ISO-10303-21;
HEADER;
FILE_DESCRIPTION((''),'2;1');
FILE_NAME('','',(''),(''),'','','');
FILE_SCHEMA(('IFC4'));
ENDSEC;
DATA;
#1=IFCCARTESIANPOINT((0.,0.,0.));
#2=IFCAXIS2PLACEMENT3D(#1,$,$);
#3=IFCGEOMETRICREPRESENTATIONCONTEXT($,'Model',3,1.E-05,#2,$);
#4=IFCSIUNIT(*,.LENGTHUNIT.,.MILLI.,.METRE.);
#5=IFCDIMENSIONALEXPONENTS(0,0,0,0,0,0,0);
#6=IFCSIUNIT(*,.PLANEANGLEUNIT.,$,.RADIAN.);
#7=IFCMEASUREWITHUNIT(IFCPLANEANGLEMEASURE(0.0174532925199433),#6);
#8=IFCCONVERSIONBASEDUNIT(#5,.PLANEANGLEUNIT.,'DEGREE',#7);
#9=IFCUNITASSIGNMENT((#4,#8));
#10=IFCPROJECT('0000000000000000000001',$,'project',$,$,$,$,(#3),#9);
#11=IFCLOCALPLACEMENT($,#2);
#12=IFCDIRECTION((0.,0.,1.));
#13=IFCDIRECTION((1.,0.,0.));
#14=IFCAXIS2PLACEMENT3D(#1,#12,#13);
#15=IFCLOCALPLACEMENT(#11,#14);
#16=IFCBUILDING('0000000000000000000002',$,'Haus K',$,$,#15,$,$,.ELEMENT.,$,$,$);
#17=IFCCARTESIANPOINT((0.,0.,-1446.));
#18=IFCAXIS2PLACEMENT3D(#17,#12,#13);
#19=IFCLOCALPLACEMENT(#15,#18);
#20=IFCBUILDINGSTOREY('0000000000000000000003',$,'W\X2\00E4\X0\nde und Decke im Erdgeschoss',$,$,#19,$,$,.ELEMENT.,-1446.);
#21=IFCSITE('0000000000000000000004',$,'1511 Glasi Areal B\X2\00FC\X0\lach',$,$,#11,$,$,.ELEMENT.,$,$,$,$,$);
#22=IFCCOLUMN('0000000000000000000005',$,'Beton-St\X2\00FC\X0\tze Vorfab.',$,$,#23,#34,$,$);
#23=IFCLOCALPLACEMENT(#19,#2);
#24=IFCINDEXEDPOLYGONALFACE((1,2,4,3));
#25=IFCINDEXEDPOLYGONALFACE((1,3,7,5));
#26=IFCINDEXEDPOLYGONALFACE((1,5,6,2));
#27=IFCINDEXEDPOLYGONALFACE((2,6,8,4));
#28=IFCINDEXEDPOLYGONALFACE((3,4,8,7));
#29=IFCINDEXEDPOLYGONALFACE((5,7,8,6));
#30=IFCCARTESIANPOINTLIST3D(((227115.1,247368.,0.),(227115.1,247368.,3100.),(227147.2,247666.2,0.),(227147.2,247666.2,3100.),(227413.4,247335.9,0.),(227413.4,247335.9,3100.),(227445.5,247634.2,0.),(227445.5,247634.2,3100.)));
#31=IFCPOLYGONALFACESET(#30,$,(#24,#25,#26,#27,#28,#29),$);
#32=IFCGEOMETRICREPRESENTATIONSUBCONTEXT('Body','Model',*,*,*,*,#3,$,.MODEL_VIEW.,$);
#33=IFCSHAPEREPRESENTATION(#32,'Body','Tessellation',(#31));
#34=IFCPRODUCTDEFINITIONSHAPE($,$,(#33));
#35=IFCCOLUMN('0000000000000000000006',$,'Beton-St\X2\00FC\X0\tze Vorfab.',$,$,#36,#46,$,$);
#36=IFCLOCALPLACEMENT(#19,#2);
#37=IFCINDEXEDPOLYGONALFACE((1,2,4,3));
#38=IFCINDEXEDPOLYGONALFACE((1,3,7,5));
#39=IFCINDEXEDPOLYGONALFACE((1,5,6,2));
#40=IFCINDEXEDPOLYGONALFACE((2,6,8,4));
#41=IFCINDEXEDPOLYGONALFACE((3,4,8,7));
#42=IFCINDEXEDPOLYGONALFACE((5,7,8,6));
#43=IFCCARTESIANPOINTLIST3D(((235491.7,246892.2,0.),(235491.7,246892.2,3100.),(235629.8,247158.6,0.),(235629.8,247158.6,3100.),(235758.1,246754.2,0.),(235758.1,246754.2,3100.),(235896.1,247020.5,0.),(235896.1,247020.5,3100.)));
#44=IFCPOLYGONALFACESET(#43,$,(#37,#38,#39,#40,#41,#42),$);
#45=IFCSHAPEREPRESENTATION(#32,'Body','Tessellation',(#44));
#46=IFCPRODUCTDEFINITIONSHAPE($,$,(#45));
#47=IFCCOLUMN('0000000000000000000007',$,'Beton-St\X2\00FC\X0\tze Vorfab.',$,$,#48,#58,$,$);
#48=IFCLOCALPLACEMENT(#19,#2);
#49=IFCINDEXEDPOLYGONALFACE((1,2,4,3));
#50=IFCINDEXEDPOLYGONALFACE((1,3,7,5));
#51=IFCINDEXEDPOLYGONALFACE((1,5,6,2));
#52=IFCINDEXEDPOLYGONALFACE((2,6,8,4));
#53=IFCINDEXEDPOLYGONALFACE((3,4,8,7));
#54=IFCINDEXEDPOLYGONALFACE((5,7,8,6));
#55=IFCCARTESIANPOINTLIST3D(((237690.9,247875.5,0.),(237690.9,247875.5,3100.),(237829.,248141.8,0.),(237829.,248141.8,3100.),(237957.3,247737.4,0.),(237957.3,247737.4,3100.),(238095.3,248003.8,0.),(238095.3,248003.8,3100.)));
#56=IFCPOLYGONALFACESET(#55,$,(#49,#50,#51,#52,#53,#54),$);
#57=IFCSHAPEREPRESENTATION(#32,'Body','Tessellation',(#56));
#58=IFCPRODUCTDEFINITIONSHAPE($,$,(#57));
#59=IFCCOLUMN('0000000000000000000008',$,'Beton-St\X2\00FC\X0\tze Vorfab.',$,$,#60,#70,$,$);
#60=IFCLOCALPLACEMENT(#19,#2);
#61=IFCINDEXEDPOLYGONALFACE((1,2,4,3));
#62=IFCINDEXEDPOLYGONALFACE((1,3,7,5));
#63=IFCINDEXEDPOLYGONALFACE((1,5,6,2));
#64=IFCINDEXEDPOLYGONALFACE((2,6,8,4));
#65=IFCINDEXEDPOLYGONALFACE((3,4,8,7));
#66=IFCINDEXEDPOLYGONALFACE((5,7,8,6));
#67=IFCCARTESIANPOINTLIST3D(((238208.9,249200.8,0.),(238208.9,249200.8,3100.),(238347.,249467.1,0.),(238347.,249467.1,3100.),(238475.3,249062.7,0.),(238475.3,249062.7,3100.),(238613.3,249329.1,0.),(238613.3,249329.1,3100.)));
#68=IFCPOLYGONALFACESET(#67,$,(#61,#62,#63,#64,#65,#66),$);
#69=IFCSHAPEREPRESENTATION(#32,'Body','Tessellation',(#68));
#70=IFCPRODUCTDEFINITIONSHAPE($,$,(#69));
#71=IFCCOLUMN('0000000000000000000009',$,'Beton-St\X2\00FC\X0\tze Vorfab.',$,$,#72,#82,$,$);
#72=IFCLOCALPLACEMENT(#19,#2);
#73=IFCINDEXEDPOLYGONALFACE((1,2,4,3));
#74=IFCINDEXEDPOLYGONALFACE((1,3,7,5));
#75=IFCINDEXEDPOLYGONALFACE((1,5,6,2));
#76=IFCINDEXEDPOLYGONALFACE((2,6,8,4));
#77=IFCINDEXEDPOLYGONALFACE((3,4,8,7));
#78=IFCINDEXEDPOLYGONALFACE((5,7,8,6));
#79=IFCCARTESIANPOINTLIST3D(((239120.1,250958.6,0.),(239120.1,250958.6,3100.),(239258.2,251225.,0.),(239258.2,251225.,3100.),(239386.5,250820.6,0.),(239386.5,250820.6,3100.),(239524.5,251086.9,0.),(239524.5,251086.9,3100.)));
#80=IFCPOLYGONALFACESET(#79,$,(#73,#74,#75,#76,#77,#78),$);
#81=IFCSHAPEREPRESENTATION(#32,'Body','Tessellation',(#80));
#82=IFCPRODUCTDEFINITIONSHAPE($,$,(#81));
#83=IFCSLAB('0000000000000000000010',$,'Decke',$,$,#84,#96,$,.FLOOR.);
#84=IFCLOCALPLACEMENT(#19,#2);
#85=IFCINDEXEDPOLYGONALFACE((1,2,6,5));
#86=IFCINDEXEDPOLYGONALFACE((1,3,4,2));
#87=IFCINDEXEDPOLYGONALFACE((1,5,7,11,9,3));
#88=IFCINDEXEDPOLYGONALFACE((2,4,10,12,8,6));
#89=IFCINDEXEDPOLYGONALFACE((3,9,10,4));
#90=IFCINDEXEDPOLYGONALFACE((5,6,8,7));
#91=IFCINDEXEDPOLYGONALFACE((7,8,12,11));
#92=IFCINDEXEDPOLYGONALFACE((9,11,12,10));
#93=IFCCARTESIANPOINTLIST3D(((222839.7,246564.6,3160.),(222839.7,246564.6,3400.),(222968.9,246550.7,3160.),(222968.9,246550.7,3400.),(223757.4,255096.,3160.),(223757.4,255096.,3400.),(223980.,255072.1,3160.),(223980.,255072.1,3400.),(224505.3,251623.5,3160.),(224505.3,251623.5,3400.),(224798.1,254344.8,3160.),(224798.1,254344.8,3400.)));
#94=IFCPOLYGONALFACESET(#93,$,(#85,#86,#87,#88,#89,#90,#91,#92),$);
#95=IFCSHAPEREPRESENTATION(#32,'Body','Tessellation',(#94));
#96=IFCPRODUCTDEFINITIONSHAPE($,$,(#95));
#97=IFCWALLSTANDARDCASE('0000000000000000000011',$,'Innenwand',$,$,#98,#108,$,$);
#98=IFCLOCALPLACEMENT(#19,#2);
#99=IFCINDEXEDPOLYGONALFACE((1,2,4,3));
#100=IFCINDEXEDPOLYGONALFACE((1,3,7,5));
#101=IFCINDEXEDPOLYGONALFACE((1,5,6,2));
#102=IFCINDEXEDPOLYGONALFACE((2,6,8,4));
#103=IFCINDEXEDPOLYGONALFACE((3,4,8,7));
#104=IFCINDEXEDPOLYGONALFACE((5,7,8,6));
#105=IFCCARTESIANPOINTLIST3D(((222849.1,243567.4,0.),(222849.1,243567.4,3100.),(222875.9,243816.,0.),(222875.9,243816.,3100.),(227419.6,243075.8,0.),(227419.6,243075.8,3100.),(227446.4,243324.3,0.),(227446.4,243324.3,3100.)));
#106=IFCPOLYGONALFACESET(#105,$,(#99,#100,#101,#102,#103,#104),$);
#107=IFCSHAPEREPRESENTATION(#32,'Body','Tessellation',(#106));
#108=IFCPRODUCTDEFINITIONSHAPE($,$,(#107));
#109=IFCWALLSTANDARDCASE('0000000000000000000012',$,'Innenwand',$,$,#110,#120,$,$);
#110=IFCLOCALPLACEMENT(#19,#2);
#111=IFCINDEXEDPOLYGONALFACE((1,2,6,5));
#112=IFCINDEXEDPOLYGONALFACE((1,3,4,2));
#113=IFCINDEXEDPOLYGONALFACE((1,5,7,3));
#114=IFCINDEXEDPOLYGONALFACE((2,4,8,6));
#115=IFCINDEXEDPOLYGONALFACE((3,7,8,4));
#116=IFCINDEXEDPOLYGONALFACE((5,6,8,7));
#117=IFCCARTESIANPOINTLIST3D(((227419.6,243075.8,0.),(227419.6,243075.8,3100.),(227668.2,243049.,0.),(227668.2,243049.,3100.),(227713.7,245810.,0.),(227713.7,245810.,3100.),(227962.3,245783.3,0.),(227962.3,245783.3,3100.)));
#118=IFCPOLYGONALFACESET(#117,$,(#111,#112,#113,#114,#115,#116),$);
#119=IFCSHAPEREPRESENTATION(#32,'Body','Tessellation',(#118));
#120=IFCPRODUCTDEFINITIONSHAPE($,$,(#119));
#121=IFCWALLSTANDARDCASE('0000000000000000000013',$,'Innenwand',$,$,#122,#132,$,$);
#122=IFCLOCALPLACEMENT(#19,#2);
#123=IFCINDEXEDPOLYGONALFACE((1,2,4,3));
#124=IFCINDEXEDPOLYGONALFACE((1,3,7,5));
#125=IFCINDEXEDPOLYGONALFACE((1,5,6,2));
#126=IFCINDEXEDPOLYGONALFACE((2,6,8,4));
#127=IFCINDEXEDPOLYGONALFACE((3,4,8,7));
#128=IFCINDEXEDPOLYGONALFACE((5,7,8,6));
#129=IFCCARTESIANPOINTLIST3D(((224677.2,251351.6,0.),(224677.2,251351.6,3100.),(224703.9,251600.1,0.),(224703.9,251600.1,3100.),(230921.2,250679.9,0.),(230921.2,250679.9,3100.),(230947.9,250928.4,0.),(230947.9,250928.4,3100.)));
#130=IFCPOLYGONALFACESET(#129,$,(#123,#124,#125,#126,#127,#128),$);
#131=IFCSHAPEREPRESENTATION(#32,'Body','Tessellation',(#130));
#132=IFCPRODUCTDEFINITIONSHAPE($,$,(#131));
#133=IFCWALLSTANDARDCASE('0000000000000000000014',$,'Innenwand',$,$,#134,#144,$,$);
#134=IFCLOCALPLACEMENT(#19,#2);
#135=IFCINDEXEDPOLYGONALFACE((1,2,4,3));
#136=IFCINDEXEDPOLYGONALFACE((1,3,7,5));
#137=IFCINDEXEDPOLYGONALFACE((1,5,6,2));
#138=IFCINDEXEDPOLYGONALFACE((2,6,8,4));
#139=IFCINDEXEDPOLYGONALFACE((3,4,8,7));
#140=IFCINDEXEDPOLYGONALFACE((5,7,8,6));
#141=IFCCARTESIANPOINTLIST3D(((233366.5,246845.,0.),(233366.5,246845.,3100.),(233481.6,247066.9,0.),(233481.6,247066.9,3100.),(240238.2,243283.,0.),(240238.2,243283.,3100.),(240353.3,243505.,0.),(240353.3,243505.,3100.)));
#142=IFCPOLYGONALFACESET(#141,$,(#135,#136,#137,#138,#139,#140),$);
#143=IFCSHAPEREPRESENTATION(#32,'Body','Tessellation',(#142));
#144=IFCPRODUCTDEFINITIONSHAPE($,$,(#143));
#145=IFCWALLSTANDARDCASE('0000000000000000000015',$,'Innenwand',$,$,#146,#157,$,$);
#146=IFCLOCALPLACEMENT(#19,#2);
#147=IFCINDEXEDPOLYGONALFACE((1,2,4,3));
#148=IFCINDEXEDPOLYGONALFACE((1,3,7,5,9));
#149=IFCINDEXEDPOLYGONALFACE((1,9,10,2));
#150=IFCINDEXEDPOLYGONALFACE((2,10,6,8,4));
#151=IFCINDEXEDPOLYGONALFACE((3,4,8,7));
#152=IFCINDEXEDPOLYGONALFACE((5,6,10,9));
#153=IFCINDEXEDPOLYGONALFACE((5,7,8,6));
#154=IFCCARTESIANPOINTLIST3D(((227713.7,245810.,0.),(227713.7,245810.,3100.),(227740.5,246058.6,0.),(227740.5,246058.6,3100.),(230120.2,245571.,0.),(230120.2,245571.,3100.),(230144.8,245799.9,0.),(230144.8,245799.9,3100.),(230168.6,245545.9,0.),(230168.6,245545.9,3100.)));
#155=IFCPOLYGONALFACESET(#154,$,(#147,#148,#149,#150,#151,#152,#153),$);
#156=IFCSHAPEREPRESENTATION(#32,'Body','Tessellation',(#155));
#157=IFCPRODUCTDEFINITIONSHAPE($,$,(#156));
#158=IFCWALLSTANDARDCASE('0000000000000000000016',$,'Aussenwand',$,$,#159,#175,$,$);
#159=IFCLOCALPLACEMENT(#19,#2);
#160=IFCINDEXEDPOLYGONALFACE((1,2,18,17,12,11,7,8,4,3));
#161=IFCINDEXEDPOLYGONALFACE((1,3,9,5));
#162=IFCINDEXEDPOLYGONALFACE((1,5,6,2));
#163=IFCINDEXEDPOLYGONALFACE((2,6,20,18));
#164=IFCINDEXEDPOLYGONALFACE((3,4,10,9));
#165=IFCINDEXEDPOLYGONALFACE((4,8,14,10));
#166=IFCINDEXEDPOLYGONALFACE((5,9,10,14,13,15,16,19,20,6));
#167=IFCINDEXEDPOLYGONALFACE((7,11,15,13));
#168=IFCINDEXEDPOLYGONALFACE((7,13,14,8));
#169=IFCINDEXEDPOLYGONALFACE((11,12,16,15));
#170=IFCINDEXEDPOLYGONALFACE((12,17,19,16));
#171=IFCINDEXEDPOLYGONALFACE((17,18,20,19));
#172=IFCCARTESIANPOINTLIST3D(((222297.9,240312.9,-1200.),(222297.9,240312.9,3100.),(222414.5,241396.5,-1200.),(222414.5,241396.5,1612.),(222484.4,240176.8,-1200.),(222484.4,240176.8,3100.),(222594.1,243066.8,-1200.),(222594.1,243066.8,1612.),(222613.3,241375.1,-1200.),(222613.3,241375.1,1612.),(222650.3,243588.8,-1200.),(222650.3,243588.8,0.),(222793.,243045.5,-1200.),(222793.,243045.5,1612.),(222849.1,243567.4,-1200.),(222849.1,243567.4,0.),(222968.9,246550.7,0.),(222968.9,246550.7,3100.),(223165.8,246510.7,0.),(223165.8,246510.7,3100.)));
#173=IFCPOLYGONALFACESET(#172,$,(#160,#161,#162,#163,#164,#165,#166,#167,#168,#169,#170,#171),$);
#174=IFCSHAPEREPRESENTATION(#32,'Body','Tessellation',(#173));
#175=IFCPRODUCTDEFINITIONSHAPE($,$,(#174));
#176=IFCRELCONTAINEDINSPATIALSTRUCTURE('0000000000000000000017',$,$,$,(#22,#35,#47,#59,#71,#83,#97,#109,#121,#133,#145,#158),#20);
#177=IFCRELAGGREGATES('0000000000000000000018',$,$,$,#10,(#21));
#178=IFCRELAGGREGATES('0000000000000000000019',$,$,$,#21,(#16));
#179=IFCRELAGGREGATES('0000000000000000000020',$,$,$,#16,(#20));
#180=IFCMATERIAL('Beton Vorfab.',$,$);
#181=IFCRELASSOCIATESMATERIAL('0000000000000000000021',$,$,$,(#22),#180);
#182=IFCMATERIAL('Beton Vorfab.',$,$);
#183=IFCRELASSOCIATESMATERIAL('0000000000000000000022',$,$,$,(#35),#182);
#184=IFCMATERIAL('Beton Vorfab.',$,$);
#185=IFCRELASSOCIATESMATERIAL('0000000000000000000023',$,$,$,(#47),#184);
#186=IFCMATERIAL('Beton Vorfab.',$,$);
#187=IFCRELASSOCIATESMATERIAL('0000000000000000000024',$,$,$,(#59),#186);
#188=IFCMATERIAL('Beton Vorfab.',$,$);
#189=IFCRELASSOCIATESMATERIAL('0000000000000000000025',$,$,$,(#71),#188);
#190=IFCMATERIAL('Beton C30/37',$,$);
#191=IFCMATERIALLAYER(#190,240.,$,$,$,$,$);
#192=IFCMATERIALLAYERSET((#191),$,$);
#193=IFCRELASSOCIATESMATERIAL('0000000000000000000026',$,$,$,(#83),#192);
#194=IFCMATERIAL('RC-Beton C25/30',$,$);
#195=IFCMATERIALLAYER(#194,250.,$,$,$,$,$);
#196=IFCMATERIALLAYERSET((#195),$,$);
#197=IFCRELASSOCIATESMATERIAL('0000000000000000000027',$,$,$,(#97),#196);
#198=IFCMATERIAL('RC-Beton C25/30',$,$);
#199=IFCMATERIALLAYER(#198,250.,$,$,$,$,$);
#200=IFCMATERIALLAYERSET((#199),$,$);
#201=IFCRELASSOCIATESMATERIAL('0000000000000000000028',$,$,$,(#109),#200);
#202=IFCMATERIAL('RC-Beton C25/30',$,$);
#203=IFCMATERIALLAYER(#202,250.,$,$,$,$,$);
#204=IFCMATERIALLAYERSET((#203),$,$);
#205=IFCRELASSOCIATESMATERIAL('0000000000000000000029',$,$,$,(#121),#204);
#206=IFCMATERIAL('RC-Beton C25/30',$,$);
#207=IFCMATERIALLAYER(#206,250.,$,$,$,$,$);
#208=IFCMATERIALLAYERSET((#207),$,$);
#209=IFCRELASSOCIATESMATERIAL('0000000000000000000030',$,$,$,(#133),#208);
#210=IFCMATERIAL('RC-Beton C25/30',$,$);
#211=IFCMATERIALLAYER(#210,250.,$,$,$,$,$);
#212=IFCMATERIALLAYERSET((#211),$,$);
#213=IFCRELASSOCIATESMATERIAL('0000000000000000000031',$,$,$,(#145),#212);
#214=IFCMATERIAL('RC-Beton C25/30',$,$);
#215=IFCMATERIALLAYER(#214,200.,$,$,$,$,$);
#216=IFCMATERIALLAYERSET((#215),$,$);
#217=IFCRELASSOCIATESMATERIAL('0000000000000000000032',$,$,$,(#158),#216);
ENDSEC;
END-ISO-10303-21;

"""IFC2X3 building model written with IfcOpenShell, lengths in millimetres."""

from ifc_helpers import new_model, entity, si_unit, converted_unit, frame, frame_2d, origin, origin_with_axes, place, context, subcontext, project, spatial, polyline, rectangle, outline, extrude, clip, bounded_halfspace, material, layer, layer_set, layer_usage, element, save


model = new_model("IFC2X3")

# Units and contexts
model_context = context("Model", 3, precision=1e-05, world=origin())
body_context = subcontext(model_context, "Body", "Model", "MODEL_VIEW")
ifc_project = project(units=[si_unit("LENGTHUNIT", "METRE", prefix="MILLI"), converted_unit("PLANEANGLEUNIT", "DEGREE", entity("IfcPlaneAngleMeasure", 0.0174532925199433), si_unit("PLANEANGLEUNIT", "RADIAN"), dimensions=[0, 0, 0, 0, 0, 0, 0])], contexts=[model_context])

# Site, building, storey
site_placement = place(None, origin())
site = spatial("IfcSite", under=ifc_project, at=site_placement, Name="1511 Glasi Areal Bülach", CompositionType="ELEMENT")
building_placement = place(site_placement, origin_with_axes())
building = spatial("IfcBuilding", under=site, at=building_placement, Name="Haus K", CompositionType="ELEMENT")
storey_placement = place(building_placement, frame((0.0, 0.0, -1446.0), z_axis=(0.0, 0.0, 1.0), x_axis=(1.0, 0.0, 0.0)))
storey = spatial("IfcBuildingStorey", under=building, at=storey_placement, Name="Wände und Decke im Erdgeschoss", CompositionType="ELEMENT", Elevation=-1446.0)

# Columns
ifc_material_1 = material(Name="Beton Vorfab.")
column_1_placement = place(storey_placement, frame((227115.1, 247368.0, 0.0), z_axis=(0.0, 0.0, 1.0), x_axis=(1.0, 0.0, 0.0)))
element("IfcColumn", 1, at=column_1_placement, inside=storey, material=ifc_material_1, Name="Beton-Stütze Vorfab.", context=body_context, shape_type="SweptSolid", body=[
    extrude(rectangle(XDim=300.0, YDim=300.0, at=frame_2d((165.2, 133.1), x_axis=(0.994264, -0.106958))), origin_with_axes(), (0.0, 0.0, 1.0), 3100.0),
])
ifc_material_2 = material(Name="Beton Vorfab.")
column_2_placement = place(storey_placement, frame((235491.7, 246892.2, 0.0), z_axis=(0.0, 0.0, 1.0), x_axis=(1.0, 0.0, 0.0)))
element("IfcColumn", 2, at=column_2_placement, inside=storey, material=ifc_material_2, Name="Beton-Stütze Vorfab.", context=body_context, shape_type="SweptSolid", body=[
    extrude(rectangle(XDim=300.0, YDim=300.0, at=frame_2d((202.2, 64.1), x_axis=(0.887815, -0.4602))), origin_with_axes(), (0.0, 0.0, 1.0), 3100.0),
])
ifc_material_3 = material(Name="Beton Vorfab.")
column_3_placement = place(storey_placement, frame((237690.9, 247875.5, 0.0), z_axis=(0.0, 0.0, 1.0), x_axis=(1.0, 0.0, 0.0)))
element("IfcColumn", 3, at=column_3_placement, inside=storey, material=ifc_material_3, Name="Beton-Stütze Vorfab.", context=body_context, shape_type="SweptSolid", body=[
    extrude(rectangle(XDim=300.0, YDim=300.0, at=frame_2d((202.2, 64.1), x_axis=(0.887815, -0.4602))), origin_with_axes(), (0.0, 0.0, 1.0), 3100.0),
])
ifc_material_4 = material(Name="Beton Vorfab.")
column_4_placement = place(storey_placement, frame((238208.9, 249200.8, 0.0), z_axis=(0.0, 0.0, 1.0), x_axis=(1.0, 0.0, 0.0)))
element("IfcColumn", 4, at=column_4_placement, inside=storey, material=ifc_material_4, Name="Beton-Stütze Vorfab.", context=body_context, shape_type="SweptSolid", body=[
    extrude(rectangle(XDim=300.0, YDim=300.0, at=frame_2d((202.2, 64.1), x_axis=(0.887815, -0.4602))), origin_with_axes(), (0.0, 0.0, 1.0), 3100.0),
])
ifc_material_5 = material(Name="Beton Vorfab.")
column_5_placement = place(storey_placement, frame((239120.1, 250958.6, 0.0), z_axis=(0.0, 0.0, 1.0), x_axis=(1.0, 0.0, 0.0)))
element("IfcColumn", 5, at=column_5_placement, inside=storey, material=ifc_material_5, Name="Beton-Stütze Vorfab.", context=body_context, shape_type="SweptSolid", body=[
    extrude(rectangle(XDim=300.0, YDim=300.0, at=frame_2d((202.2, 64.1), x_axis=(0.887815, -0.4602))), origin_with_axes(), (0.0, 0.0, 1.0), 3100.0),
])

# Slab
ifc_material_6 = material(Name="Beton C30/37")
ifc_layer_1 = layer(ifc_material_6, 240.0)
ifc_layer_set_1 = layer_set([ifc_layer_1])
ifc_layer_usage_1 = layer_usage(ifc_layer_set_1, "AXIS3", "POSITIVE", 0.0)
slab_placement = place(storey_placement, frame((222839.7, 246550.7, 3160.0), z_axis=(0.0, 0.0, 1.0), x_axis=(1.0, 0.0, 0.0)))
element("IfcSlab", 6, at=slab_placement, inside=storey, material=ifc_layer_usage_1, Name="Decke", PredefinedType="FLOOR", context=body_context, shape_type="SweptSolid", body=[
    extrude(outline(polyline([(917.8, 8545.3), (0.0, 13.9), (129.3, 0.0), (1665.6, 5072.8), (1958.4, 7794.1), (1140.4, 8521.4), (917.8, 8545.3)])), origin_with_axes(), (0.0, 0.0, 1.0), 240.0),
])

# Walls
ifc_material_7 = material(Name="RC-Beton C25/30")
ifc_layer_2 = layer(ifc_material_7, 250.0)
ifc_layer_set_2 = layer_set([ifc_layer_2])
ifc_layer_usage_2 = layer_usage(ifc_layer_set_2, "AXIS2", "POSITIVE", 0.0)
wall_1_placement = place(storey_placement, frame((227446.4, 243324.3, 0.0), z_axis=(0.0, 0.0, 1.0), x_axis=(-0.994264, 0.106958, 0.0)))
element("IfcWallStandardCase", 7, at=wall_1_placement, inside=storey, material=ifc_layer_usage_2, Name="Innenwand", context=body_context, shape_type="SweptSolid", body=[
    extrude(rectangle(XDim=4596.8, YDim=250.0, at=frame_2d((2298.4, 125.0), x_axis=(1.0, 0.0))), origin_with_axes(), (0.0, 0.0, 1.0), 3100.0),
])
ifc_material_8 = material(Name="RC-Beton C25/30")
ifc_layer_3 = layer(ifc_material_8, 250.0)
ifc_layer_set_3 = layer_set([ifc_layer_3])
ifc_layer_usage_3 = layer_usage(ifc_layer_set_3, "AXIS2", "POSITIVE", 0.0)
wall_2_placement = place(storey_placement, frame((227713.7, 245810.0, 0.0), z_axis=(0.0, 0.0, 1.0), x_axis=(-0.106958, -0.994264, 0.0)))
element("IfcWallStandardCase", 8, at=wall_2_placement, inside=storey, material=ifc_layer_usage_3, Name="Innenwand", context=body_context, shape_type="SweptSolid", body=[
    extrude(rectangle(XDim=2750.0, YDim=250.0, at=frame_2d((1375.0, 125.0), x_axis=(1.0, 0.0))), origin_with_axes(), (0.0, 0.0, 1.0), 3100.0),
])
ifc_material_9 = material(Name="RC-Beton C25/30")
ifc_layer_4 = layer(ifc_material_9, 250.0)
ifc_layer_set_4 = layer_set([ifc_layer_4])
ifc_layer_usage_4 = layer_usage(ifc_layer_set_4, "AXIS2", "POSITIVE", 0.0)
wall_3_placement = place(storey_placement, frame((230947.9, 250928.4, 0.0), z_axis=(0.0, 0.0, 1.0), x_axis=(-0.994264, 0.106958, 0.0)))
element("IfcWallStandardCase", 9, at=wall_3_placement, inside=storey, material=ifc_layer_usage_4, Name="Innenwand", context=body_context, shape_type="SweptSolid", body=[
    extrude(rectangle(XDim=6280.0, YDim=250.0, at=frame_2d((3140.0, 125.0), x_axis=(1.0, 0.0))), origin_with_axes(), (0.0, 0.0, 1.0), 3100.0),
])
ifc_material_10 = material(Name="RC-Beton C25/30")
ifc_layer_5 = layer(ifc_material_10, 250.0)
ifc_layer_set_5 = layer_set([ifc_layer_5])
ifc_layer_usage_5 = layer_usage(ifc_layer_set_5, "AXIS2", "POSITIVE", 0.0)
wall_4_placement = place(storey_placement, frame((233366.5, 246845.0, 0.0), z_axis=(0.0, 0.0, 1.0), x_axis=(0.887815, -0.4602, 0.0)))
element("IfcWallStandardCase", 10, at=wall_4_placement, inside=storey, material=ifc_layer_usage_5, Name="Innenwand", context=body_context, shape_type="SweptSolid", body=[
    extrude(rectangle(XDim=7740.0, YDim=250.0, at=frame_2d((3870.0, 125.0), x_axis=(1.0, 0.0))), origin_with_axes(), (0.0, 0.0, 1.0), 3100.0),
])
ifc_material_11 = material(Name="RC-Beton C25/30")
ifc_layer_6 = layer(ifc_material_11, 250.0)
ifc_layer_set_6 = layer_set([ifc_layer_6])
ifc_layer_usage_6 = layer_usage(ifc_layer_set_6, "AXIS2", "POSITIVE", 0.0)
wall_5_placement = place(storey_placement, frame((230144.8, 245799.9, 0.0), z_axis=(0.0, 0.0, 1.0), x_axis=(-0.994264, 0.106958, 0.0)))
element("IfcWallStandardCase", 11, at=wall_5_placement, inside=storey, material=ifc_layer_usage_6, Name="Innenwand", context=body_context, shape_type="SweptSolid", body=[
    extrude(outline(polyline([(0.0, 0.0), (2418.2, 0.0), (2418.2, 250.0), (-50.8, 250.0), (0.0, 230.2), (0.0, 0.0)])), origin_with_axes(), (0.0, 0.0, 1.0), 3100.0),
])

# Wall, opening
ifc_material_12 = material(Name="RC-Beton C25/30")
ifc_layer_7 = layer(ifc_material_12, 200.0)
ifc_layer_set_7 = layer_set([ifc_layer_7])
ifc_layer_usage_7 = layer_usage(ifc_layer_set_7, "AXIS2", "POSITIVE", 0.0)
wall_6_placement = place(storey_placement, frame((222968.9, 246550.7, -1200.0), z_axis=(0.0, 0.0, 1.0), x_axis=(-0.106958, -0.994264, 0.0)))
wall_6 = element("IfcWallStandardCase", 12, at=wall_6_placement, inside=storey, material=ifc_layer_usage_7, Name="Aussenwand", context=body_context, shape_type="Clipping", body=[
    clip(clip(extrude(outline(polyline([(0.0, 0.0), (6273.8, 0.0), (6389.2, 200.0), (18.7, 200.0), (0.0, 0.0)])), origin_with_axes(), (0.0, 0.0, 1.0), 4300.0), bounded_halfspace(frame((2979.0, 200.0, 0.0), z_axis=(0.0, 0.0, 1.0), x_axis=(0.0, -1.0, 0.0)), True, origin(), polyline([(2979.0, 200.0), (2979.0, 0.0), (6273.8, 0.0), (6389.2, 200.0), (2979.0, 200.0)]))), bounded_halfspace(frame((0.0, 0.0, 1200.0), z_axis=(0.0, 0.0, 1.0), x_axis=(1.0, 0.0, 0.0)), True, origin(), polyline([(0.0, 0.0), (2979.0, 0.0), (2979.0, 200.0), (18.7, 200.0), (0.0, 0.0)]))),
])
opening_1_placement = place(wall_6_placement, frame((3504.0, 0.0, 0.0), z_axis=(0.0, 1.0, 0.0), x_axis=(0.0, 0.0, 1.0)))
element("IfcOpeningElement", 13, at=opening_1_placement, cuts=wall_6, ObjectType="Opening", context=body_context, shape_type="SweptSolid", body=[
    extrude(rectangle(XDim=2812.0, YDim=1680.0, at=frame_2d((1406.0, 840.0), x_axis=(1.0, 0.0))), origin_with_axes(), (0.0, 0.0, 1.0), 200.0),
])

save(model, "model.ifc")
